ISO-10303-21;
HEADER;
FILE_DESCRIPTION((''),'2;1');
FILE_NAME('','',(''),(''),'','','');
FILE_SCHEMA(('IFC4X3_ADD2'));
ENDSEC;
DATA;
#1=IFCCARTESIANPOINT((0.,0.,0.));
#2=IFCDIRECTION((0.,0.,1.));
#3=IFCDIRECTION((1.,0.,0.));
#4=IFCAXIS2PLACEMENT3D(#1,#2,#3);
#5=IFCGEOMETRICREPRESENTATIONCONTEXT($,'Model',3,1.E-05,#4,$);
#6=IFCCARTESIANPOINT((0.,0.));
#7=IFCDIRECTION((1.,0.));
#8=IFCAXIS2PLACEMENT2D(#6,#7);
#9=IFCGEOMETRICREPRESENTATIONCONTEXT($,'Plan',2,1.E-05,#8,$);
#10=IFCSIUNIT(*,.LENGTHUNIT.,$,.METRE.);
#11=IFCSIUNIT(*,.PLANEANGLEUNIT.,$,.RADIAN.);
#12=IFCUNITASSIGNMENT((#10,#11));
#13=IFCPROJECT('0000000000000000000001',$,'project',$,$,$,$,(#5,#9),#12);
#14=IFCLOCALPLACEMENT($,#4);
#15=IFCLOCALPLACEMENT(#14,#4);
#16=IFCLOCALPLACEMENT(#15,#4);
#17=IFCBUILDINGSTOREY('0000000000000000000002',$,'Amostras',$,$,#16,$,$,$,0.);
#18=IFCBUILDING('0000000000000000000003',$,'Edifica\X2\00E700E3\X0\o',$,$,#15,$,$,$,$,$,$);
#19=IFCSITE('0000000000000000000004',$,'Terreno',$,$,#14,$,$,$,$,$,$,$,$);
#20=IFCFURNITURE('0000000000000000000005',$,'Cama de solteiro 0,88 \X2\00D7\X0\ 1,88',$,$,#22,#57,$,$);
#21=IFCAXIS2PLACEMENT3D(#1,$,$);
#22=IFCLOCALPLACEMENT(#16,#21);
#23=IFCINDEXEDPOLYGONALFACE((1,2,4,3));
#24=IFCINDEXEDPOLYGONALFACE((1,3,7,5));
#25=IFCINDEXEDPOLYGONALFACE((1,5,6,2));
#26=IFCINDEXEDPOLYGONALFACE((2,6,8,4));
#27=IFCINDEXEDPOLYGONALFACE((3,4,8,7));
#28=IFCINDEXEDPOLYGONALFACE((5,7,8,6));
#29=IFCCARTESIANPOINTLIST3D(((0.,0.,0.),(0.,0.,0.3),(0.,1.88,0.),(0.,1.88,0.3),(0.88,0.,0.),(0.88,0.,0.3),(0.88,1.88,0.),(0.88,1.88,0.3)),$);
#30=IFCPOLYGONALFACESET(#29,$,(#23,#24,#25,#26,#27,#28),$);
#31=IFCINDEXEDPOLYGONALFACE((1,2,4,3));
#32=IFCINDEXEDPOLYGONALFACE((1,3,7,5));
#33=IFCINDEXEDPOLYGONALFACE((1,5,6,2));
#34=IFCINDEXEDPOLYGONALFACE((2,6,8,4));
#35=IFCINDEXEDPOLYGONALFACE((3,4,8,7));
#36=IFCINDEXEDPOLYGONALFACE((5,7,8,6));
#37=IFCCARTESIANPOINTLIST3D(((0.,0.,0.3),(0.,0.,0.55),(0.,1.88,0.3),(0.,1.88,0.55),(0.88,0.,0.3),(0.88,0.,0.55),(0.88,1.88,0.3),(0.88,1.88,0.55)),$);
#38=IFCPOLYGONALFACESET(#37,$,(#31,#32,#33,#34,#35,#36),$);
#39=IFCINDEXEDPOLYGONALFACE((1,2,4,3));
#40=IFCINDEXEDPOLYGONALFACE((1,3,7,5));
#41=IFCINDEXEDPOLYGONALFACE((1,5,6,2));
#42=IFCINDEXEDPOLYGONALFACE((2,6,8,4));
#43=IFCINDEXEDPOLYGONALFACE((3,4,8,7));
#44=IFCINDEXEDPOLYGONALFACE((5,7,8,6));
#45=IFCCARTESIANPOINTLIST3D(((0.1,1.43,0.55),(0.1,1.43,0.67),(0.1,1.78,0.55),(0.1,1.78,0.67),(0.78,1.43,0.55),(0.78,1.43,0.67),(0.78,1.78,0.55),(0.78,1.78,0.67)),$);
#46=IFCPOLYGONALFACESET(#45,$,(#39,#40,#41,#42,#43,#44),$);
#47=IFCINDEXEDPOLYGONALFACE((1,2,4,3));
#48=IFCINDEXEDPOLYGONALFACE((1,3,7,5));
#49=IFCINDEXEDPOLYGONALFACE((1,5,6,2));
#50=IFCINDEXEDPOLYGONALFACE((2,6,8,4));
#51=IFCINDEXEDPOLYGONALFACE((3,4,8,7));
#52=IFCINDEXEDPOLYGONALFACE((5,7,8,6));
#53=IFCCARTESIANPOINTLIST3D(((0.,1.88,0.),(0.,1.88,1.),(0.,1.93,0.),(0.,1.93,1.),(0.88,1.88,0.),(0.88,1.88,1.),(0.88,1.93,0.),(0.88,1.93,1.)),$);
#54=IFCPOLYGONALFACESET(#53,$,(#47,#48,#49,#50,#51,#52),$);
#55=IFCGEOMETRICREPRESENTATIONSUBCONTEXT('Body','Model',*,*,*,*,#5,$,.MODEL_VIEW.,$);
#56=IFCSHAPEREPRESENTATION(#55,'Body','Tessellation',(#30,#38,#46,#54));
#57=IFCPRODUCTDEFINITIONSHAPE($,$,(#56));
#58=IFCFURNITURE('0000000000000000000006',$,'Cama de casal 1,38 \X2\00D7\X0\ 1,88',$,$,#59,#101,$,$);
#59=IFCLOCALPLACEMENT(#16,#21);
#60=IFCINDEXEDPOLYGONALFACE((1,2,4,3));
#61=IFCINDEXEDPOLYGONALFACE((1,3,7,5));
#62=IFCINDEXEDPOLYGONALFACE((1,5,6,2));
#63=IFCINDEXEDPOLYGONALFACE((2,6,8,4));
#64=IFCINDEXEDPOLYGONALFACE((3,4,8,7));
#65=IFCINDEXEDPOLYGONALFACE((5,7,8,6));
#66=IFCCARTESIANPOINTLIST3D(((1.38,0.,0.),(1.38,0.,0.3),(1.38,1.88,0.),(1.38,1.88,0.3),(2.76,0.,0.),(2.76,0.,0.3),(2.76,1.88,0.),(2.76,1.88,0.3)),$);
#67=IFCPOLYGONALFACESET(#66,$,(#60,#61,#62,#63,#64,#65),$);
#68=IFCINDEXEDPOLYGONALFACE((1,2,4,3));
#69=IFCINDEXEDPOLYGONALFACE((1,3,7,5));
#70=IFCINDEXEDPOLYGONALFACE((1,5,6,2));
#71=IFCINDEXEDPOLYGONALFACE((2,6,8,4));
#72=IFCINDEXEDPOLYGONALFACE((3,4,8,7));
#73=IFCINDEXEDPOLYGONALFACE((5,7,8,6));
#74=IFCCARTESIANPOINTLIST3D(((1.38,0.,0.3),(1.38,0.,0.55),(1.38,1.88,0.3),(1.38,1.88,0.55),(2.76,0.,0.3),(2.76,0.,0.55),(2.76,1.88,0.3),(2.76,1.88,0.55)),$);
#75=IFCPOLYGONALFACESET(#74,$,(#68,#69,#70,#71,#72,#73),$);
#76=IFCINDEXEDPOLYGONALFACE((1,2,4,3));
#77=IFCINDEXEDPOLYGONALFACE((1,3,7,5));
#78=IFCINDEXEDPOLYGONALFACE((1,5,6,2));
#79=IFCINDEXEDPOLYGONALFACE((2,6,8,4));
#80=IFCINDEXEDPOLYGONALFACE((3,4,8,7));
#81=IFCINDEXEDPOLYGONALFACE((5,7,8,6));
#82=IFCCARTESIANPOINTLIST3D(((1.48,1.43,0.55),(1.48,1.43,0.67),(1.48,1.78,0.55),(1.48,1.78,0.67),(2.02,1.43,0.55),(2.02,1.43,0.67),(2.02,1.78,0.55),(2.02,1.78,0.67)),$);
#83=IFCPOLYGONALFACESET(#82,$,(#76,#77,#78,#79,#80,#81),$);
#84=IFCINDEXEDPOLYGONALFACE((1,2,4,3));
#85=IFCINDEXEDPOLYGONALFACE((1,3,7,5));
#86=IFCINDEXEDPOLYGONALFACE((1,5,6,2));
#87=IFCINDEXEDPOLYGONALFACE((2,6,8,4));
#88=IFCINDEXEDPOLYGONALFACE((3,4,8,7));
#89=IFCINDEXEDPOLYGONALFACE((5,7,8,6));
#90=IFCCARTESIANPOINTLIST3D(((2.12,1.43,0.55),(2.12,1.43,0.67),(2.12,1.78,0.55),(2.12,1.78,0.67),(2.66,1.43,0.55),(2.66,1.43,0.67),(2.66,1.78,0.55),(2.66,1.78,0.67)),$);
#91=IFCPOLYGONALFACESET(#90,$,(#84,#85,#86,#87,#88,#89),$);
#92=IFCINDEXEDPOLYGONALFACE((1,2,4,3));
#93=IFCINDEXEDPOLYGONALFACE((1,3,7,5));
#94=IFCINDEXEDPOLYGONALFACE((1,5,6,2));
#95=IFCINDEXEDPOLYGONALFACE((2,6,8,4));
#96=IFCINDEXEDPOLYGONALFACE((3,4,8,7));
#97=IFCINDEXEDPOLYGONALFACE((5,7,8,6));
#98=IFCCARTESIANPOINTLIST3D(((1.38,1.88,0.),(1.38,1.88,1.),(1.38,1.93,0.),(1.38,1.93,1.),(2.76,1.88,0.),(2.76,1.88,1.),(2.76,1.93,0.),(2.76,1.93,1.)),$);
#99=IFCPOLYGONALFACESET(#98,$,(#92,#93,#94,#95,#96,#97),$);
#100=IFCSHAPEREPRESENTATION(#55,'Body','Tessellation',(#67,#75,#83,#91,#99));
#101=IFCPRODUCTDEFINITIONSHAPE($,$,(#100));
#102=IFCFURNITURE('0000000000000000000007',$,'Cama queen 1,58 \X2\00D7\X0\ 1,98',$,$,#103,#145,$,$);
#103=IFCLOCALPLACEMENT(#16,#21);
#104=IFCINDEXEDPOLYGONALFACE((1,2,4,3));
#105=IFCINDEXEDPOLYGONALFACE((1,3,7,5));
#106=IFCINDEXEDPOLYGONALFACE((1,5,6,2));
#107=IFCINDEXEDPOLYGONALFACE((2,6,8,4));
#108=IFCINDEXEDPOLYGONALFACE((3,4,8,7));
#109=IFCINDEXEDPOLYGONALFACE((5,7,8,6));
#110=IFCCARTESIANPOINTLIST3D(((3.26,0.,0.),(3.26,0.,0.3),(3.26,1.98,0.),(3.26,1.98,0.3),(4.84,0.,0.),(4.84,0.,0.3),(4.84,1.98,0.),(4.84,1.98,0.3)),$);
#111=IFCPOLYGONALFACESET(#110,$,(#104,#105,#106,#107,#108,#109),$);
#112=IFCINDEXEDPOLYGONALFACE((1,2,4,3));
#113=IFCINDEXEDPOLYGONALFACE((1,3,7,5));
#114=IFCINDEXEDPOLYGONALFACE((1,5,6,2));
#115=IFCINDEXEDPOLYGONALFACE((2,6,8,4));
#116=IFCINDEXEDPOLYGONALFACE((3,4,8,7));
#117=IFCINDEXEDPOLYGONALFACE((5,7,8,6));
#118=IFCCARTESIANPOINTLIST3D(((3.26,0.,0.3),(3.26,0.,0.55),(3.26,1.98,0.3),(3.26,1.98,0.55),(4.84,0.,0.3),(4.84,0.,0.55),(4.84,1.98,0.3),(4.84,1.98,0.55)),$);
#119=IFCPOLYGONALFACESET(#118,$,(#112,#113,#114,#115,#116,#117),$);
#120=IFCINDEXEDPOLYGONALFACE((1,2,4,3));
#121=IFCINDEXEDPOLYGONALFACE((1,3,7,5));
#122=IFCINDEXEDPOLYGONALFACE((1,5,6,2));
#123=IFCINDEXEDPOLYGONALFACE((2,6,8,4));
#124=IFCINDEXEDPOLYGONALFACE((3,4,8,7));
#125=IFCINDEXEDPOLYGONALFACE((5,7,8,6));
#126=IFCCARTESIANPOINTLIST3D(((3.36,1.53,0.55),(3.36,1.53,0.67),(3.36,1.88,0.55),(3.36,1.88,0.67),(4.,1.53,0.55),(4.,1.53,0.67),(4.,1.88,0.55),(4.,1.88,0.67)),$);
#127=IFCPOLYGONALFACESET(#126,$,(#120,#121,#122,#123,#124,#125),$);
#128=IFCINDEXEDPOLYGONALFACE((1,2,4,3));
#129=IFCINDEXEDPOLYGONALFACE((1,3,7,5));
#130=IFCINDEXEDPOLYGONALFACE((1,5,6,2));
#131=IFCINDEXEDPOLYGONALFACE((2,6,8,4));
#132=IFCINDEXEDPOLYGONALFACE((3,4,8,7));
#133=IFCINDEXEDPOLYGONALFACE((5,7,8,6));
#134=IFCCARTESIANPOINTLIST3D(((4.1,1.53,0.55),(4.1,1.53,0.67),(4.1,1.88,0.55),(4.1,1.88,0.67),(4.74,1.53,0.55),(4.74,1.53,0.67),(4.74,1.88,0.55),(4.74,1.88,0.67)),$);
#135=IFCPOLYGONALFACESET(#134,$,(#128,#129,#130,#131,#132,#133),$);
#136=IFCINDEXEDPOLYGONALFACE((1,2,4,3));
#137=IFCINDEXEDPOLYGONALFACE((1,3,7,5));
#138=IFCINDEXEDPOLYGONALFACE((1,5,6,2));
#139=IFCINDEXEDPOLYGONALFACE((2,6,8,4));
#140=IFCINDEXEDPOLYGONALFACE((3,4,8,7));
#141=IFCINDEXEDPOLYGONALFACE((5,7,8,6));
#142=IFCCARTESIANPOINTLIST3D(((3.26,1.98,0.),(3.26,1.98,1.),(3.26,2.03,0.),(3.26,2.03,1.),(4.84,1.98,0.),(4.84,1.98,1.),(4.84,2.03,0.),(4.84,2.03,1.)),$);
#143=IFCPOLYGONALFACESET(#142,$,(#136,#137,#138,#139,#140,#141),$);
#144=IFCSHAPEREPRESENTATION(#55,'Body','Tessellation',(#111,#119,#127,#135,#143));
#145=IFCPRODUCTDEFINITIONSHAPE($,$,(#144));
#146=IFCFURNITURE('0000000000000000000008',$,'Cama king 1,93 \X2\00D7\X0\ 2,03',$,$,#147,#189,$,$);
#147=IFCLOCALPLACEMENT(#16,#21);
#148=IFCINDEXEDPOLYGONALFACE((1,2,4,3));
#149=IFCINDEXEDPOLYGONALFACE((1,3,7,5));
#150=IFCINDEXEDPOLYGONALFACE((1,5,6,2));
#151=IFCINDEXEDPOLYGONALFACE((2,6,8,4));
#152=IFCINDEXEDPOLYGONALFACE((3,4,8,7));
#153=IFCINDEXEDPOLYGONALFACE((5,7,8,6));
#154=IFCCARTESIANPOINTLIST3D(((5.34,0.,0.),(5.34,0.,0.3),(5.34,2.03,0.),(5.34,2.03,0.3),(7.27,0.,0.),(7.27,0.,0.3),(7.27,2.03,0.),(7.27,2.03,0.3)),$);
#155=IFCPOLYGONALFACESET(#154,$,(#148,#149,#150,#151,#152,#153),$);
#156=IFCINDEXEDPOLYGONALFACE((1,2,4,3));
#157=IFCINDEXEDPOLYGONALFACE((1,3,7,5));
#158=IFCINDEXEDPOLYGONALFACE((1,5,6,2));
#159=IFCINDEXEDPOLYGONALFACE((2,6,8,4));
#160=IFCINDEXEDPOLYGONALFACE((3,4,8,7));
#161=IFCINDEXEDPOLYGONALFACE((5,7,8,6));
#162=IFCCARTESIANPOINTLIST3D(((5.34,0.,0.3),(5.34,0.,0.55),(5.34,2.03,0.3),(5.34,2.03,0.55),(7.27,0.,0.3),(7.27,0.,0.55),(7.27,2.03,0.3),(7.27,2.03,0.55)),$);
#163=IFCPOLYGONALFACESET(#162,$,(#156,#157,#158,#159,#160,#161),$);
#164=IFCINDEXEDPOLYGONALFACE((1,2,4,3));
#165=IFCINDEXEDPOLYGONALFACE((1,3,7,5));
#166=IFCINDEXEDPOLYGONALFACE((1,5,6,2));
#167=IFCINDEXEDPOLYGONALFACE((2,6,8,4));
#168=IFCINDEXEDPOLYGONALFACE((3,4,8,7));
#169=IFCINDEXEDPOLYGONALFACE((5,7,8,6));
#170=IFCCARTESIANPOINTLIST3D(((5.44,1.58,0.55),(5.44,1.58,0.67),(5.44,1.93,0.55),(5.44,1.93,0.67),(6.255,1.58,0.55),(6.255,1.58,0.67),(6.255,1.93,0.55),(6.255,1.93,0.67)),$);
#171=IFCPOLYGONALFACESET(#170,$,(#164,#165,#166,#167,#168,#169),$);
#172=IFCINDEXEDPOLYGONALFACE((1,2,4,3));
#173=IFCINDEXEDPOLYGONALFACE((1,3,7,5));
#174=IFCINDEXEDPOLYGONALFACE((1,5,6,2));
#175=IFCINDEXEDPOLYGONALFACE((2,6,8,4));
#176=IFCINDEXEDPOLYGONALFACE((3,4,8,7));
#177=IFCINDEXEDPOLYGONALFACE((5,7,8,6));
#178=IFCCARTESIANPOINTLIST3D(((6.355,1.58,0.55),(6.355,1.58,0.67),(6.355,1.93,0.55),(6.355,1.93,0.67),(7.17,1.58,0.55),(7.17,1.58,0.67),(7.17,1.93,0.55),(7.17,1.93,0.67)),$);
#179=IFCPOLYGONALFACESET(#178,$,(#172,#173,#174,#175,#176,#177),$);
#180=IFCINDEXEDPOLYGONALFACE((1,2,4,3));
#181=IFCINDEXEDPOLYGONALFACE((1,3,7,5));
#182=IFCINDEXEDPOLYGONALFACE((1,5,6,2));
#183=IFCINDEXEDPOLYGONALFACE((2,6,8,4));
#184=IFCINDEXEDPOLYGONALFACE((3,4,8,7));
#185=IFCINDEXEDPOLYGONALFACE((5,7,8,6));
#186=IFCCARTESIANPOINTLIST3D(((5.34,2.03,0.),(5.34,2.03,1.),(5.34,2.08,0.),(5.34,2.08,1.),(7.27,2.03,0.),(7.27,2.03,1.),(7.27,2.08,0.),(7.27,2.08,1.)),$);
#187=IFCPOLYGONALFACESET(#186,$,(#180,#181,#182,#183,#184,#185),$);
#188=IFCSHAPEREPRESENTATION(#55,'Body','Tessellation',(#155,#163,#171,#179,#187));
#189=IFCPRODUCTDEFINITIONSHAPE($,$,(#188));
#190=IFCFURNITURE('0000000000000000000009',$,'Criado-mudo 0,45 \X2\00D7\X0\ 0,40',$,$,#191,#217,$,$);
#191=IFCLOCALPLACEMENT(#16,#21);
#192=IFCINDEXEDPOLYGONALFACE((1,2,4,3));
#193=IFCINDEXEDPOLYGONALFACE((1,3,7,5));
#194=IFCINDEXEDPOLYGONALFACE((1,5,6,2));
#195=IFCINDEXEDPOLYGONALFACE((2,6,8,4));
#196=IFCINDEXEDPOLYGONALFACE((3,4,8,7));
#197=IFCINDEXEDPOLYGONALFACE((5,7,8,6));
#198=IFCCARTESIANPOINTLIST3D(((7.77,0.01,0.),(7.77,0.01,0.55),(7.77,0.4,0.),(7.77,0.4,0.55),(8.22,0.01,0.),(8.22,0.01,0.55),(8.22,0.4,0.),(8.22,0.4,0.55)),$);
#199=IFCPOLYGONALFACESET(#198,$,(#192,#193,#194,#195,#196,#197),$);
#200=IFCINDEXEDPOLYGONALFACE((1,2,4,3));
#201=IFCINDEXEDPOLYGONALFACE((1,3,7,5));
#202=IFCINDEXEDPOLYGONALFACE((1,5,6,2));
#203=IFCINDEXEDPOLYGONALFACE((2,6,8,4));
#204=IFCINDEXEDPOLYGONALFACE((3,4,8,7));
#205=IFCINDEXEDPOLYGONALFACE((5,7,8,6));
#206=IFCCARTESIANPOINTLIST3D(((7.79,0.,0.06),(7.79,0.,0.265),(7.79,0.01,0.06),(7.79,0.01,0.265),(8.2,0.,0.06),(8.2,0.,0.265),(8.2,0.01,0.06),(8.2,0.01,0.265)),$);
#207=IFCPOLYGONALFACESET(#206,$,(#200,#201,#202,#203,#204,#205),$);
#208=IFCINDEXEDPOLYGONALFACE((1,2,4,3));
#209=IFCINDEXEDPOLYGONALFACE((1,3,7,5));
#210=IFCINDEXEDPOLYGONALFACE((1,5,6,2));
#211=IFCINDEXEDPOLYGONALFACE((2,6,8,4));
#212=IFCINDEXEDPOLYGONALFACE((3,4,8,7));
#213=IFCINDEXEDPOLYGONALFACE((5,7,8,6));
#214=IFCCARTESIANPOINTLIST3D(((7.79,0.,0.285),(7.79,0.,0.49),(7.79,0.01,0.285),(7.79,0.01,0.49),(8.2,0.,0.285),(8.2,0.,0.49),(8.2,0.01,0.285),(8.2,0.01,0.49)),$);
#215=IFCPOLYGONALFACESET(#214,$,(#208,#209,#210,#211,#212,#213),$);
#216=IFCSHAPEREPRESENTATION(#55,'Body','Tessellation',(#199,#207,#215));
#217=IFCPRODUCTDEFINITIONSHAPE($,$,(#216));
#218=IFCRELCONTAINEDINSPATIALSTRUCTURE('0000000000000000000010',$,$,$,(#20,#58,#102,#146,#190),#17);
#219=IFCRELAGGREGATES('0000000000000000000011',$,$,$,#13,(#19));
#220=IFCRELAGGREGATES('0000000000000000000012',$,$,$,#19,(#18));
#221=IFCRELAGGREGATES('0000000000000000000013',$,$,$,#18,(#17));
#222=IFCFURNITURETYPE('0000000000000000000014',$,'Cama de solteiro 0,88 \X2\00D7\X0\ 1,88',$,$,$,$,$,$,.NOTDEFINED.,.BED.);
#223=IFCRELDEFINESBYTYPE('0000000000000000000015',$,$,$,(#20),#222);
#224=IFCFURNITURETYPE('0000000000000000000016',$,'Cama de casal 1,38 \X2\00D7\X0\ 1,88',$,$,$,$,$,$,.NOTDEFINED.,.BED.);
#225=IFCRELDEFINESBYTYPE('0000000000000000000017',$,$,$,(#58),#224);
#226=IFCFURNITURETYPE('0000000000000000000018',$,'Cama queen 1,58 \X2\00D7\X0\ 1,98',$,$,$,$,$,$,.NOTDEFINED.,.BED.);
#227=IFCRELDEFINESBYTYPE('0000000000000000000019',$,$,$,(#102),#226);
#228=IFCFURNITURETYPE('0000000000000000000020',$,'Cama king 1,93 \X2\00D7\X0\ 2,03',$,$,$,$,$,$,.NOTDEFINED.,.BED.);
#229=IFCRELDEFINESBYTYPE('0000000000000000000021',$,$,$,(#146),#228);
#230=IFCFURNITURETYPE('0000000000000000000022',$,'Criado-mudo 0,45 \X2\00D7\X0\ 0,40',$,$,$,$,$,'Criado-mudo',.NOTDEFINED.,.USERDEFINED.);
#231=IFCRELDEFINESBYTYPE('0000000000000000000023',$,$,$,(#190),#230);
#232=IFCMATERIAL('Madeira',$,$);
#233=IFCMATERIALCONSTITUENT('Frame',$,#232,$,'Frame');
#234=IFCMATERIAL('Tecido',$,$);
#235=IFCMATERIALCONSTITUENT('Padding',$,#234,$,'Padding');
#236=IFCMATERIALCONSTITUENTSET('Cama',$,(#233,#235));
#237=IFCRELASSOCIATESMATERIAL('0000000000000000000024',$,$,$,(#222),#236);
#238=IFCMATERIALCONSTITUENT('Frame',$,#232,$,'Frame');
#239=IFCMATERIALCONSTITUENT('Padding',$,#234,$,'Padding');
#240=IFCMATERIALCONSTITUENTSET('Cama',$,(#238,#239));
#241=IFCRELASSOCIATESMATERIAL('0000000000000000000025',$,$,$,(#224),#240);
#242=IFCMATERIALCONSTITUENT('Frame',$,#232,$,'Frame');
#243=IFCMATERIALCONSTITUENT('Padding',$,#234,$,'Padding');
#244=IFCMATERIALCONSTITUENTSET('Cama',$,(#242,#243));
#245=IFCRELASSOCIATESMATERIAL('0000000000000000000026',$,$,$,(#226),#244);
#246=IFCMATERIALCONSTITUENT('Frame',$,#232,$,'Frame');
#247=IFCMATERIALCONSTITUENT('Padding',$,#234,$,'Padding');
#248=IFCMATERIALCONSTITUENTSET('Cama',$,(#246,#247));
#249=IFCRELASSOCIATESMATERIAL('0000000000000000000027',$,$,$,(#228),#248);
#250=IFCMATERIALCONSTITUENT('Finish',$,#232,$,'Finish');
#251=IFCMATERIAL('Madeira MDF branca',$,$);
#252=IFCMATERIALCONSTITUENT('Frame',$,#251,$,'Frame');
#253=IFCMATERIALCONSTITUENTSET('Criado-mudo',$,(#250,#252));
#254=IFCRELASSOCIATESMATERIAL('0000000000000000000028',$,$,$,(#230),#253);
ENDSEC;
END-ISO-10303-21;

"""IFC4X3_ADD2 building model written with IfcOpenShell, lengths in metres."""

from ifc_helpers import new_model, si_unit, frame, frame_2d, origin, origin_with_axes, origin_2d_with_axis, place, context, subcontext, project, spatial, rectangle, extrude, material, constituent, constituent_set, type_object, element, save


model = new_model("IFC4X3_ADD2")

# Units and contexts
model_context = context("Model", 3, precision=1e-05, world=origin_with_axes())
plan_context = context("Plan", 2, precision=1e-05, world=origin_2d_with_axis())
body_context = subcontext(model_context, "Body", "Model", "MODEL_VIEW")
ifc_project = project(units=[si_unit("LENGTHUNIT", "METRE"), si_unit("PLANEANGLEUNIT", "RADIAN")], contexts=[model_context, plan_context])

# Site, building, storey
site_placement = place(None, origin_with_axes())
site = spatial("IfcSite", under=ifc_project, at=site_placement, Name="Terreno")
building_placement = place(site_placement, origin_with_axes())
building = spatial("IfcBuilding", under=site, at=building_placement, Name="Edificação")
storey_placement = place(building_placement, origin_with_axes())
storey = spatial("IfcBuildingStorey", under=building, at=storey_placement, Name="Amostras", Elevation=0.0)

# Furniture
ifc_material_1 = material(Name="Madeira")
ifc_constituent_1 = constituent(ifc_material_1, Name="Frame", Category="Frame")
ifc_material_2 = material(Name="Tecido")
ifc_constituent_2 = constituent(ifc_material_2, Name="Padding", Category="Padding")
ifc_constituent_set_1 = constituent_set(constituents=[ifc_constituent_1, ifc_constituent_2], Name="Cama")
furniture_type_1 = type_object("IfcFurnitureType", Name="Cama de solteiro 0,88 × 1,88", AssemblyPlace="NOTDEFINED", PredefinedType="BED", material=ifc_constituent_set_1)
furniture_1_placement = place(storey_placement, origin_with_axes())
element("IfcFurniture", 1, at=furniture_1_placement, inside=storey, type_object=furniture_type_1, Name="Cama de solteiro 0,88 × 1,88", context=body_context, shape_type="SweptSolid", body=[
    extrude(rectangle(XDim=0.88, YDim=1.88, at=frame_2d((0.44, 0.94), x_axis=(1.0, 0.0))), origin(), (0.0, 0.0, 1.0), 0.3),
    extrude(rectangle(XDim=0.88, YDim=1.88, at=frame_2d((0.44, 0.94), x_axis=(1.0, 0.0))), frame((0.0, 0.0, 0.3)), (0.0, 0.0, 1.0), 0.25),
    extrude(rectangle(XDim=0.68, YDim=0.35, at=frame_2d((0.44, 1.605), x_axis=(1.0, 0.0))), frame((0.0, 0.0, 0.55)), (0.0, 0.0, 1.0), 0.12),
    extrude(rectangle(XDim=0.88, YDim=0.05, at=frame_2d((0.44, 1.905), x_axis=(1.0, 0.0))), origin(), (0.0, 0.0, 1.0), 1.0),
])
ifc_constituent_3 = constituent(ifc_material_1, Name="Frame", Category="Frame")
ifc_constituent_4 = constituent(ifc_material_2, Name="Padding", Category="Padding")
ifc_constituent_set_2 = constituent_set(constituents=[ifc_constituent_3, ifc_constituent_4], Name="Cama")
furniture_type_2 = type_object("IfcFurnitureType", Name="Cama de casal 1,38 × 1,88", AssemblyPlace="NOTDEFINED", PredefinedType="BED", material=ifc_constituent_set_2)
furniture_2_placement = place(storey_placement, frame((1.38, 0.0, 0.0), z_axis=(0.0, 0.0, 1.0), x_axis=(1.0, 0.0, 0.0)))
element("IfcFurniture", 2, at=furniture_2_placement, inside=storey, type_object=furniture_type_2, Name="Cama de casal 1,38 × 1,88", context=body_context, shape_type="SweptSolid", body=[
    extrude(rectangle(XDim=1.38, YDim=1.88, at=frame_2d((0.69, 0.94), x_axis=(1.0, 0.0))), origin(), (0.0, 0.0, 1.0), 0.3),
    extrude(rectangle(XDim=1.38, YDim=1.88, at=frame_2d((0.69, 0.94), x_axis=(1.0, 0.0))), frame((0.0, 0.0, 0.3)), (0.0, 0.0, 1.0), 0.25),
    extrude(rectangle(XDim=0.54, YDim=0.35, at=frame_2d((0.37, 1.605), x_axis=(1.0, 0.0))), frame((0.0, 0.0, 0.55)), (0.0, 0.0, 1.0), 0.12),
    extrude(rectangle(XDim=0.54, YDim=0.35, at=frame_2d((1.01, 1.605), x_axis=(1.0, 0.0))), frame((0.0, 0.0, 0.55)), (0.0, 0.0, 1.0), 0.12),
    extrude(rectangle(XDim=1.38, YDim=0.05, at=frame_2d((0.69, 1.905), x_axis=(1.0, 0.0))), origin(), (0.0, 0.0, 1.0), 1.0),
])
ifc_constituent_5 = constituent(ifc_material_1, Name="Frame", Category="Frame")
ifc_constituent_6 = constituent(ifc_material_2, Name="Padding", Category="Padding")
ifc_constituent_set_3 = constituent_set(constituents=[ifc_constituent_5, ifc_constituent_6], Name="Cama")
furniture_type_3 = type_object("IfcFurnitureType", Name="Cama queen 1,58 × 1,98", AssemblyPlace="NOTDEFINED", PredefinedType="BED", material=ifc_constituent_set_3)
furniture_3_placement = place(storey_placement, frame((3.26, 0.0, 0.0), z_axis=(0.0, 0.0, 1.0), x_axis=(1.0, 0.0, 0.0)))
element("IfcFurniture", 3, at=furniture_3_placement, inside=storey, type_object=furniture_type_3, Name="Cama queen 1,58 × 1,98", context=body_context, shape_type="SweptSolid", body=[
    extrude(rectangle(XDim=1.58, YDim=1.98, at=frame_2d((0.79, 0.99), x_axis=(1.0, 0.0))), origin(), (0.0, 0.0, 1.0), 0.3),
    extrude(rectangle(XDim=1.58, YDim=1.98, at=frame_2d((0.79, 0.99), x_axis=(1.0, 0.0))), frame((0.0, 0.0, 0.3)), (0.0, 0.0, 1.0), 0.25),
    extrude(rectangle(XDim=0.64, YDim=0.35, at=frame_2d((0.42, 1.705), x_axis=(1.0, 0.0))), frame((0.0, 0.0, 0.55)), (0.0, 0.0, 1.0), 0.12),
    extrude(rectangle(XDim=0.64, YDim=0.35, at=frame_2d((1.16, 1.705), x_axis=(1.0, 0.0))), frame((0.0, 0.0, 0.55)), (0.0, 0.0, 1.0), 0.12),
    extrude(rectangle(XDim=1.58, YDim=0.05, at=frame_2d((0.79, 2.005), x_axis=(1.0, 0.0))), origin(), (0.0, 0.0, 1.0), 1.0),
])
ifc_constituent_7 = constituent(ifc_material_1, Name="Frame", Category="Frame")
ifc_constituent_8 = constituent(ifc_material_2, Name="Padding", Category="Padding")
ifc_constituent_set_4 = constituent_set(constituents=[ifc_constituent_7, ifc_constituent_8], Name="Cama")
furniture_type_4 = type_object("IfcFurnitureType", Name="Cama king 1,93 × 2,03", AssemblyPlace="NOTDEFINED", PredefinedType="BED", material=ifc_constituent_set_4)
furniture_4_placement = place(storey_placement, frame((5.34, 0.0, 0.0), z_axis=(0.0, 0.0, 1.0), x_axis=(1.0, 0.0, 0.0)))
element("IfcFurniture", 4, at=furniture_4_placement, inside=storey, type_object=furniture_type_4, Name="Cama king 1,93 × 2,03", context=body_context, shape_type="SweptSolid", body=[
    extrude(rectangle(XDim=1.93, YDim=2.03, at=frame_2d((0.965, 1.015), x_axis=(1.0, 0.0))), origin(), (0.0, 0.0, 1.0), 0.3),
    extrude(rectangle(XDim=1.93, YDim=2.03, at=frame_2d((0.965, 1.015), x_axis=(1.0, 0.0))), frame((0.0, 0.0, 0.3)), (0.0, 0.0, 1.0), 0.25),
    extrude(rectangle(XDim=0.815, YDim=0.35, at=frame_2d((0.5075, 1.755), x_axis=(1.0, 0.0))), frame((0.0, 0.0, 0.55)), (0.0, 0.0, 1.0), 0.12),
    extrude(rectangle(XDim=0.815, YDim=0.35, at=frame_2d((1.4225, 1.755), x_axis=(1.0, 0.0))), frame((0.0, 0.0, 0.55)), (0.0, 0.0, 1.0), 0.12),
    extrude(rectangle(XDim=1.93, YDim=0.05, at=frame_2d((0.965, 2.055), x_axis=(1.0, 0.0))), origin(), (0.0, 0.0, 1.0), 1.0),
])
ifc_constituent_9 = constituent(ifc_material_1, Name="Finish", Category="Finish")
ifc_material_3 = material(Name="Madeira MDF branca")
ifc_constituent_10 = constituent(ifc_material_3, Name="Frame", Category="Frame")
ifc_constituent_set_5 = constituent_set(constituents=[ifc_constituent_9, ifc_constituent_10], Name="Criado-mudo")
furniture_type_5 = type_object("IfcFurnitureType", Name="Criado-mudo 0,45 × 0,40", ElementType="Criado-mudo", AssemblyPlace="NOTDEFINED", PredefinedType="USERDEFINED", material=ifc_constituent_set_5)
furniture_5_placement = place(storey_placement, frame((7.77, 0.0, 0.0), z_axis=(0.0, 0.0, 1.0), x_axis=(1.0, 0.0, 0.0)))
element("IfcFurniture", 5, at=furniture_5_placement, inside=storey, type_object=furniture_type_5, Name="Criado-mudo 0,45 × 0,40", context=body_context, shape_type="SweptSolid", body=[
    extrude(rectangle(XDim=0.45, YDim=0.39, at=frame_2d((0.225, 0.205), x_axis=(1.0, 0.0))), origin(), (0.0, 0.0, 1.0), 0.55),
    extrude(rectangle(XDim=0.41, YDim=0.01, at=frame_2d((0.225, 0.005), x_axis=(1.0, 0.0))), frame((0.0, 0.0, 0.06)), (0.0, 0.0, 1.0), 0.205),
    extrude(rectangle(XDim=0.41, YDim=0.01, at=frame_2d((0.225, 0.005), x_axis=(1.0, 0.0))), frame((0.0, 0.0, 0.285)), (0.0, 0.0, 1.0), 0.205),
])

save(model, "model.ifc")
